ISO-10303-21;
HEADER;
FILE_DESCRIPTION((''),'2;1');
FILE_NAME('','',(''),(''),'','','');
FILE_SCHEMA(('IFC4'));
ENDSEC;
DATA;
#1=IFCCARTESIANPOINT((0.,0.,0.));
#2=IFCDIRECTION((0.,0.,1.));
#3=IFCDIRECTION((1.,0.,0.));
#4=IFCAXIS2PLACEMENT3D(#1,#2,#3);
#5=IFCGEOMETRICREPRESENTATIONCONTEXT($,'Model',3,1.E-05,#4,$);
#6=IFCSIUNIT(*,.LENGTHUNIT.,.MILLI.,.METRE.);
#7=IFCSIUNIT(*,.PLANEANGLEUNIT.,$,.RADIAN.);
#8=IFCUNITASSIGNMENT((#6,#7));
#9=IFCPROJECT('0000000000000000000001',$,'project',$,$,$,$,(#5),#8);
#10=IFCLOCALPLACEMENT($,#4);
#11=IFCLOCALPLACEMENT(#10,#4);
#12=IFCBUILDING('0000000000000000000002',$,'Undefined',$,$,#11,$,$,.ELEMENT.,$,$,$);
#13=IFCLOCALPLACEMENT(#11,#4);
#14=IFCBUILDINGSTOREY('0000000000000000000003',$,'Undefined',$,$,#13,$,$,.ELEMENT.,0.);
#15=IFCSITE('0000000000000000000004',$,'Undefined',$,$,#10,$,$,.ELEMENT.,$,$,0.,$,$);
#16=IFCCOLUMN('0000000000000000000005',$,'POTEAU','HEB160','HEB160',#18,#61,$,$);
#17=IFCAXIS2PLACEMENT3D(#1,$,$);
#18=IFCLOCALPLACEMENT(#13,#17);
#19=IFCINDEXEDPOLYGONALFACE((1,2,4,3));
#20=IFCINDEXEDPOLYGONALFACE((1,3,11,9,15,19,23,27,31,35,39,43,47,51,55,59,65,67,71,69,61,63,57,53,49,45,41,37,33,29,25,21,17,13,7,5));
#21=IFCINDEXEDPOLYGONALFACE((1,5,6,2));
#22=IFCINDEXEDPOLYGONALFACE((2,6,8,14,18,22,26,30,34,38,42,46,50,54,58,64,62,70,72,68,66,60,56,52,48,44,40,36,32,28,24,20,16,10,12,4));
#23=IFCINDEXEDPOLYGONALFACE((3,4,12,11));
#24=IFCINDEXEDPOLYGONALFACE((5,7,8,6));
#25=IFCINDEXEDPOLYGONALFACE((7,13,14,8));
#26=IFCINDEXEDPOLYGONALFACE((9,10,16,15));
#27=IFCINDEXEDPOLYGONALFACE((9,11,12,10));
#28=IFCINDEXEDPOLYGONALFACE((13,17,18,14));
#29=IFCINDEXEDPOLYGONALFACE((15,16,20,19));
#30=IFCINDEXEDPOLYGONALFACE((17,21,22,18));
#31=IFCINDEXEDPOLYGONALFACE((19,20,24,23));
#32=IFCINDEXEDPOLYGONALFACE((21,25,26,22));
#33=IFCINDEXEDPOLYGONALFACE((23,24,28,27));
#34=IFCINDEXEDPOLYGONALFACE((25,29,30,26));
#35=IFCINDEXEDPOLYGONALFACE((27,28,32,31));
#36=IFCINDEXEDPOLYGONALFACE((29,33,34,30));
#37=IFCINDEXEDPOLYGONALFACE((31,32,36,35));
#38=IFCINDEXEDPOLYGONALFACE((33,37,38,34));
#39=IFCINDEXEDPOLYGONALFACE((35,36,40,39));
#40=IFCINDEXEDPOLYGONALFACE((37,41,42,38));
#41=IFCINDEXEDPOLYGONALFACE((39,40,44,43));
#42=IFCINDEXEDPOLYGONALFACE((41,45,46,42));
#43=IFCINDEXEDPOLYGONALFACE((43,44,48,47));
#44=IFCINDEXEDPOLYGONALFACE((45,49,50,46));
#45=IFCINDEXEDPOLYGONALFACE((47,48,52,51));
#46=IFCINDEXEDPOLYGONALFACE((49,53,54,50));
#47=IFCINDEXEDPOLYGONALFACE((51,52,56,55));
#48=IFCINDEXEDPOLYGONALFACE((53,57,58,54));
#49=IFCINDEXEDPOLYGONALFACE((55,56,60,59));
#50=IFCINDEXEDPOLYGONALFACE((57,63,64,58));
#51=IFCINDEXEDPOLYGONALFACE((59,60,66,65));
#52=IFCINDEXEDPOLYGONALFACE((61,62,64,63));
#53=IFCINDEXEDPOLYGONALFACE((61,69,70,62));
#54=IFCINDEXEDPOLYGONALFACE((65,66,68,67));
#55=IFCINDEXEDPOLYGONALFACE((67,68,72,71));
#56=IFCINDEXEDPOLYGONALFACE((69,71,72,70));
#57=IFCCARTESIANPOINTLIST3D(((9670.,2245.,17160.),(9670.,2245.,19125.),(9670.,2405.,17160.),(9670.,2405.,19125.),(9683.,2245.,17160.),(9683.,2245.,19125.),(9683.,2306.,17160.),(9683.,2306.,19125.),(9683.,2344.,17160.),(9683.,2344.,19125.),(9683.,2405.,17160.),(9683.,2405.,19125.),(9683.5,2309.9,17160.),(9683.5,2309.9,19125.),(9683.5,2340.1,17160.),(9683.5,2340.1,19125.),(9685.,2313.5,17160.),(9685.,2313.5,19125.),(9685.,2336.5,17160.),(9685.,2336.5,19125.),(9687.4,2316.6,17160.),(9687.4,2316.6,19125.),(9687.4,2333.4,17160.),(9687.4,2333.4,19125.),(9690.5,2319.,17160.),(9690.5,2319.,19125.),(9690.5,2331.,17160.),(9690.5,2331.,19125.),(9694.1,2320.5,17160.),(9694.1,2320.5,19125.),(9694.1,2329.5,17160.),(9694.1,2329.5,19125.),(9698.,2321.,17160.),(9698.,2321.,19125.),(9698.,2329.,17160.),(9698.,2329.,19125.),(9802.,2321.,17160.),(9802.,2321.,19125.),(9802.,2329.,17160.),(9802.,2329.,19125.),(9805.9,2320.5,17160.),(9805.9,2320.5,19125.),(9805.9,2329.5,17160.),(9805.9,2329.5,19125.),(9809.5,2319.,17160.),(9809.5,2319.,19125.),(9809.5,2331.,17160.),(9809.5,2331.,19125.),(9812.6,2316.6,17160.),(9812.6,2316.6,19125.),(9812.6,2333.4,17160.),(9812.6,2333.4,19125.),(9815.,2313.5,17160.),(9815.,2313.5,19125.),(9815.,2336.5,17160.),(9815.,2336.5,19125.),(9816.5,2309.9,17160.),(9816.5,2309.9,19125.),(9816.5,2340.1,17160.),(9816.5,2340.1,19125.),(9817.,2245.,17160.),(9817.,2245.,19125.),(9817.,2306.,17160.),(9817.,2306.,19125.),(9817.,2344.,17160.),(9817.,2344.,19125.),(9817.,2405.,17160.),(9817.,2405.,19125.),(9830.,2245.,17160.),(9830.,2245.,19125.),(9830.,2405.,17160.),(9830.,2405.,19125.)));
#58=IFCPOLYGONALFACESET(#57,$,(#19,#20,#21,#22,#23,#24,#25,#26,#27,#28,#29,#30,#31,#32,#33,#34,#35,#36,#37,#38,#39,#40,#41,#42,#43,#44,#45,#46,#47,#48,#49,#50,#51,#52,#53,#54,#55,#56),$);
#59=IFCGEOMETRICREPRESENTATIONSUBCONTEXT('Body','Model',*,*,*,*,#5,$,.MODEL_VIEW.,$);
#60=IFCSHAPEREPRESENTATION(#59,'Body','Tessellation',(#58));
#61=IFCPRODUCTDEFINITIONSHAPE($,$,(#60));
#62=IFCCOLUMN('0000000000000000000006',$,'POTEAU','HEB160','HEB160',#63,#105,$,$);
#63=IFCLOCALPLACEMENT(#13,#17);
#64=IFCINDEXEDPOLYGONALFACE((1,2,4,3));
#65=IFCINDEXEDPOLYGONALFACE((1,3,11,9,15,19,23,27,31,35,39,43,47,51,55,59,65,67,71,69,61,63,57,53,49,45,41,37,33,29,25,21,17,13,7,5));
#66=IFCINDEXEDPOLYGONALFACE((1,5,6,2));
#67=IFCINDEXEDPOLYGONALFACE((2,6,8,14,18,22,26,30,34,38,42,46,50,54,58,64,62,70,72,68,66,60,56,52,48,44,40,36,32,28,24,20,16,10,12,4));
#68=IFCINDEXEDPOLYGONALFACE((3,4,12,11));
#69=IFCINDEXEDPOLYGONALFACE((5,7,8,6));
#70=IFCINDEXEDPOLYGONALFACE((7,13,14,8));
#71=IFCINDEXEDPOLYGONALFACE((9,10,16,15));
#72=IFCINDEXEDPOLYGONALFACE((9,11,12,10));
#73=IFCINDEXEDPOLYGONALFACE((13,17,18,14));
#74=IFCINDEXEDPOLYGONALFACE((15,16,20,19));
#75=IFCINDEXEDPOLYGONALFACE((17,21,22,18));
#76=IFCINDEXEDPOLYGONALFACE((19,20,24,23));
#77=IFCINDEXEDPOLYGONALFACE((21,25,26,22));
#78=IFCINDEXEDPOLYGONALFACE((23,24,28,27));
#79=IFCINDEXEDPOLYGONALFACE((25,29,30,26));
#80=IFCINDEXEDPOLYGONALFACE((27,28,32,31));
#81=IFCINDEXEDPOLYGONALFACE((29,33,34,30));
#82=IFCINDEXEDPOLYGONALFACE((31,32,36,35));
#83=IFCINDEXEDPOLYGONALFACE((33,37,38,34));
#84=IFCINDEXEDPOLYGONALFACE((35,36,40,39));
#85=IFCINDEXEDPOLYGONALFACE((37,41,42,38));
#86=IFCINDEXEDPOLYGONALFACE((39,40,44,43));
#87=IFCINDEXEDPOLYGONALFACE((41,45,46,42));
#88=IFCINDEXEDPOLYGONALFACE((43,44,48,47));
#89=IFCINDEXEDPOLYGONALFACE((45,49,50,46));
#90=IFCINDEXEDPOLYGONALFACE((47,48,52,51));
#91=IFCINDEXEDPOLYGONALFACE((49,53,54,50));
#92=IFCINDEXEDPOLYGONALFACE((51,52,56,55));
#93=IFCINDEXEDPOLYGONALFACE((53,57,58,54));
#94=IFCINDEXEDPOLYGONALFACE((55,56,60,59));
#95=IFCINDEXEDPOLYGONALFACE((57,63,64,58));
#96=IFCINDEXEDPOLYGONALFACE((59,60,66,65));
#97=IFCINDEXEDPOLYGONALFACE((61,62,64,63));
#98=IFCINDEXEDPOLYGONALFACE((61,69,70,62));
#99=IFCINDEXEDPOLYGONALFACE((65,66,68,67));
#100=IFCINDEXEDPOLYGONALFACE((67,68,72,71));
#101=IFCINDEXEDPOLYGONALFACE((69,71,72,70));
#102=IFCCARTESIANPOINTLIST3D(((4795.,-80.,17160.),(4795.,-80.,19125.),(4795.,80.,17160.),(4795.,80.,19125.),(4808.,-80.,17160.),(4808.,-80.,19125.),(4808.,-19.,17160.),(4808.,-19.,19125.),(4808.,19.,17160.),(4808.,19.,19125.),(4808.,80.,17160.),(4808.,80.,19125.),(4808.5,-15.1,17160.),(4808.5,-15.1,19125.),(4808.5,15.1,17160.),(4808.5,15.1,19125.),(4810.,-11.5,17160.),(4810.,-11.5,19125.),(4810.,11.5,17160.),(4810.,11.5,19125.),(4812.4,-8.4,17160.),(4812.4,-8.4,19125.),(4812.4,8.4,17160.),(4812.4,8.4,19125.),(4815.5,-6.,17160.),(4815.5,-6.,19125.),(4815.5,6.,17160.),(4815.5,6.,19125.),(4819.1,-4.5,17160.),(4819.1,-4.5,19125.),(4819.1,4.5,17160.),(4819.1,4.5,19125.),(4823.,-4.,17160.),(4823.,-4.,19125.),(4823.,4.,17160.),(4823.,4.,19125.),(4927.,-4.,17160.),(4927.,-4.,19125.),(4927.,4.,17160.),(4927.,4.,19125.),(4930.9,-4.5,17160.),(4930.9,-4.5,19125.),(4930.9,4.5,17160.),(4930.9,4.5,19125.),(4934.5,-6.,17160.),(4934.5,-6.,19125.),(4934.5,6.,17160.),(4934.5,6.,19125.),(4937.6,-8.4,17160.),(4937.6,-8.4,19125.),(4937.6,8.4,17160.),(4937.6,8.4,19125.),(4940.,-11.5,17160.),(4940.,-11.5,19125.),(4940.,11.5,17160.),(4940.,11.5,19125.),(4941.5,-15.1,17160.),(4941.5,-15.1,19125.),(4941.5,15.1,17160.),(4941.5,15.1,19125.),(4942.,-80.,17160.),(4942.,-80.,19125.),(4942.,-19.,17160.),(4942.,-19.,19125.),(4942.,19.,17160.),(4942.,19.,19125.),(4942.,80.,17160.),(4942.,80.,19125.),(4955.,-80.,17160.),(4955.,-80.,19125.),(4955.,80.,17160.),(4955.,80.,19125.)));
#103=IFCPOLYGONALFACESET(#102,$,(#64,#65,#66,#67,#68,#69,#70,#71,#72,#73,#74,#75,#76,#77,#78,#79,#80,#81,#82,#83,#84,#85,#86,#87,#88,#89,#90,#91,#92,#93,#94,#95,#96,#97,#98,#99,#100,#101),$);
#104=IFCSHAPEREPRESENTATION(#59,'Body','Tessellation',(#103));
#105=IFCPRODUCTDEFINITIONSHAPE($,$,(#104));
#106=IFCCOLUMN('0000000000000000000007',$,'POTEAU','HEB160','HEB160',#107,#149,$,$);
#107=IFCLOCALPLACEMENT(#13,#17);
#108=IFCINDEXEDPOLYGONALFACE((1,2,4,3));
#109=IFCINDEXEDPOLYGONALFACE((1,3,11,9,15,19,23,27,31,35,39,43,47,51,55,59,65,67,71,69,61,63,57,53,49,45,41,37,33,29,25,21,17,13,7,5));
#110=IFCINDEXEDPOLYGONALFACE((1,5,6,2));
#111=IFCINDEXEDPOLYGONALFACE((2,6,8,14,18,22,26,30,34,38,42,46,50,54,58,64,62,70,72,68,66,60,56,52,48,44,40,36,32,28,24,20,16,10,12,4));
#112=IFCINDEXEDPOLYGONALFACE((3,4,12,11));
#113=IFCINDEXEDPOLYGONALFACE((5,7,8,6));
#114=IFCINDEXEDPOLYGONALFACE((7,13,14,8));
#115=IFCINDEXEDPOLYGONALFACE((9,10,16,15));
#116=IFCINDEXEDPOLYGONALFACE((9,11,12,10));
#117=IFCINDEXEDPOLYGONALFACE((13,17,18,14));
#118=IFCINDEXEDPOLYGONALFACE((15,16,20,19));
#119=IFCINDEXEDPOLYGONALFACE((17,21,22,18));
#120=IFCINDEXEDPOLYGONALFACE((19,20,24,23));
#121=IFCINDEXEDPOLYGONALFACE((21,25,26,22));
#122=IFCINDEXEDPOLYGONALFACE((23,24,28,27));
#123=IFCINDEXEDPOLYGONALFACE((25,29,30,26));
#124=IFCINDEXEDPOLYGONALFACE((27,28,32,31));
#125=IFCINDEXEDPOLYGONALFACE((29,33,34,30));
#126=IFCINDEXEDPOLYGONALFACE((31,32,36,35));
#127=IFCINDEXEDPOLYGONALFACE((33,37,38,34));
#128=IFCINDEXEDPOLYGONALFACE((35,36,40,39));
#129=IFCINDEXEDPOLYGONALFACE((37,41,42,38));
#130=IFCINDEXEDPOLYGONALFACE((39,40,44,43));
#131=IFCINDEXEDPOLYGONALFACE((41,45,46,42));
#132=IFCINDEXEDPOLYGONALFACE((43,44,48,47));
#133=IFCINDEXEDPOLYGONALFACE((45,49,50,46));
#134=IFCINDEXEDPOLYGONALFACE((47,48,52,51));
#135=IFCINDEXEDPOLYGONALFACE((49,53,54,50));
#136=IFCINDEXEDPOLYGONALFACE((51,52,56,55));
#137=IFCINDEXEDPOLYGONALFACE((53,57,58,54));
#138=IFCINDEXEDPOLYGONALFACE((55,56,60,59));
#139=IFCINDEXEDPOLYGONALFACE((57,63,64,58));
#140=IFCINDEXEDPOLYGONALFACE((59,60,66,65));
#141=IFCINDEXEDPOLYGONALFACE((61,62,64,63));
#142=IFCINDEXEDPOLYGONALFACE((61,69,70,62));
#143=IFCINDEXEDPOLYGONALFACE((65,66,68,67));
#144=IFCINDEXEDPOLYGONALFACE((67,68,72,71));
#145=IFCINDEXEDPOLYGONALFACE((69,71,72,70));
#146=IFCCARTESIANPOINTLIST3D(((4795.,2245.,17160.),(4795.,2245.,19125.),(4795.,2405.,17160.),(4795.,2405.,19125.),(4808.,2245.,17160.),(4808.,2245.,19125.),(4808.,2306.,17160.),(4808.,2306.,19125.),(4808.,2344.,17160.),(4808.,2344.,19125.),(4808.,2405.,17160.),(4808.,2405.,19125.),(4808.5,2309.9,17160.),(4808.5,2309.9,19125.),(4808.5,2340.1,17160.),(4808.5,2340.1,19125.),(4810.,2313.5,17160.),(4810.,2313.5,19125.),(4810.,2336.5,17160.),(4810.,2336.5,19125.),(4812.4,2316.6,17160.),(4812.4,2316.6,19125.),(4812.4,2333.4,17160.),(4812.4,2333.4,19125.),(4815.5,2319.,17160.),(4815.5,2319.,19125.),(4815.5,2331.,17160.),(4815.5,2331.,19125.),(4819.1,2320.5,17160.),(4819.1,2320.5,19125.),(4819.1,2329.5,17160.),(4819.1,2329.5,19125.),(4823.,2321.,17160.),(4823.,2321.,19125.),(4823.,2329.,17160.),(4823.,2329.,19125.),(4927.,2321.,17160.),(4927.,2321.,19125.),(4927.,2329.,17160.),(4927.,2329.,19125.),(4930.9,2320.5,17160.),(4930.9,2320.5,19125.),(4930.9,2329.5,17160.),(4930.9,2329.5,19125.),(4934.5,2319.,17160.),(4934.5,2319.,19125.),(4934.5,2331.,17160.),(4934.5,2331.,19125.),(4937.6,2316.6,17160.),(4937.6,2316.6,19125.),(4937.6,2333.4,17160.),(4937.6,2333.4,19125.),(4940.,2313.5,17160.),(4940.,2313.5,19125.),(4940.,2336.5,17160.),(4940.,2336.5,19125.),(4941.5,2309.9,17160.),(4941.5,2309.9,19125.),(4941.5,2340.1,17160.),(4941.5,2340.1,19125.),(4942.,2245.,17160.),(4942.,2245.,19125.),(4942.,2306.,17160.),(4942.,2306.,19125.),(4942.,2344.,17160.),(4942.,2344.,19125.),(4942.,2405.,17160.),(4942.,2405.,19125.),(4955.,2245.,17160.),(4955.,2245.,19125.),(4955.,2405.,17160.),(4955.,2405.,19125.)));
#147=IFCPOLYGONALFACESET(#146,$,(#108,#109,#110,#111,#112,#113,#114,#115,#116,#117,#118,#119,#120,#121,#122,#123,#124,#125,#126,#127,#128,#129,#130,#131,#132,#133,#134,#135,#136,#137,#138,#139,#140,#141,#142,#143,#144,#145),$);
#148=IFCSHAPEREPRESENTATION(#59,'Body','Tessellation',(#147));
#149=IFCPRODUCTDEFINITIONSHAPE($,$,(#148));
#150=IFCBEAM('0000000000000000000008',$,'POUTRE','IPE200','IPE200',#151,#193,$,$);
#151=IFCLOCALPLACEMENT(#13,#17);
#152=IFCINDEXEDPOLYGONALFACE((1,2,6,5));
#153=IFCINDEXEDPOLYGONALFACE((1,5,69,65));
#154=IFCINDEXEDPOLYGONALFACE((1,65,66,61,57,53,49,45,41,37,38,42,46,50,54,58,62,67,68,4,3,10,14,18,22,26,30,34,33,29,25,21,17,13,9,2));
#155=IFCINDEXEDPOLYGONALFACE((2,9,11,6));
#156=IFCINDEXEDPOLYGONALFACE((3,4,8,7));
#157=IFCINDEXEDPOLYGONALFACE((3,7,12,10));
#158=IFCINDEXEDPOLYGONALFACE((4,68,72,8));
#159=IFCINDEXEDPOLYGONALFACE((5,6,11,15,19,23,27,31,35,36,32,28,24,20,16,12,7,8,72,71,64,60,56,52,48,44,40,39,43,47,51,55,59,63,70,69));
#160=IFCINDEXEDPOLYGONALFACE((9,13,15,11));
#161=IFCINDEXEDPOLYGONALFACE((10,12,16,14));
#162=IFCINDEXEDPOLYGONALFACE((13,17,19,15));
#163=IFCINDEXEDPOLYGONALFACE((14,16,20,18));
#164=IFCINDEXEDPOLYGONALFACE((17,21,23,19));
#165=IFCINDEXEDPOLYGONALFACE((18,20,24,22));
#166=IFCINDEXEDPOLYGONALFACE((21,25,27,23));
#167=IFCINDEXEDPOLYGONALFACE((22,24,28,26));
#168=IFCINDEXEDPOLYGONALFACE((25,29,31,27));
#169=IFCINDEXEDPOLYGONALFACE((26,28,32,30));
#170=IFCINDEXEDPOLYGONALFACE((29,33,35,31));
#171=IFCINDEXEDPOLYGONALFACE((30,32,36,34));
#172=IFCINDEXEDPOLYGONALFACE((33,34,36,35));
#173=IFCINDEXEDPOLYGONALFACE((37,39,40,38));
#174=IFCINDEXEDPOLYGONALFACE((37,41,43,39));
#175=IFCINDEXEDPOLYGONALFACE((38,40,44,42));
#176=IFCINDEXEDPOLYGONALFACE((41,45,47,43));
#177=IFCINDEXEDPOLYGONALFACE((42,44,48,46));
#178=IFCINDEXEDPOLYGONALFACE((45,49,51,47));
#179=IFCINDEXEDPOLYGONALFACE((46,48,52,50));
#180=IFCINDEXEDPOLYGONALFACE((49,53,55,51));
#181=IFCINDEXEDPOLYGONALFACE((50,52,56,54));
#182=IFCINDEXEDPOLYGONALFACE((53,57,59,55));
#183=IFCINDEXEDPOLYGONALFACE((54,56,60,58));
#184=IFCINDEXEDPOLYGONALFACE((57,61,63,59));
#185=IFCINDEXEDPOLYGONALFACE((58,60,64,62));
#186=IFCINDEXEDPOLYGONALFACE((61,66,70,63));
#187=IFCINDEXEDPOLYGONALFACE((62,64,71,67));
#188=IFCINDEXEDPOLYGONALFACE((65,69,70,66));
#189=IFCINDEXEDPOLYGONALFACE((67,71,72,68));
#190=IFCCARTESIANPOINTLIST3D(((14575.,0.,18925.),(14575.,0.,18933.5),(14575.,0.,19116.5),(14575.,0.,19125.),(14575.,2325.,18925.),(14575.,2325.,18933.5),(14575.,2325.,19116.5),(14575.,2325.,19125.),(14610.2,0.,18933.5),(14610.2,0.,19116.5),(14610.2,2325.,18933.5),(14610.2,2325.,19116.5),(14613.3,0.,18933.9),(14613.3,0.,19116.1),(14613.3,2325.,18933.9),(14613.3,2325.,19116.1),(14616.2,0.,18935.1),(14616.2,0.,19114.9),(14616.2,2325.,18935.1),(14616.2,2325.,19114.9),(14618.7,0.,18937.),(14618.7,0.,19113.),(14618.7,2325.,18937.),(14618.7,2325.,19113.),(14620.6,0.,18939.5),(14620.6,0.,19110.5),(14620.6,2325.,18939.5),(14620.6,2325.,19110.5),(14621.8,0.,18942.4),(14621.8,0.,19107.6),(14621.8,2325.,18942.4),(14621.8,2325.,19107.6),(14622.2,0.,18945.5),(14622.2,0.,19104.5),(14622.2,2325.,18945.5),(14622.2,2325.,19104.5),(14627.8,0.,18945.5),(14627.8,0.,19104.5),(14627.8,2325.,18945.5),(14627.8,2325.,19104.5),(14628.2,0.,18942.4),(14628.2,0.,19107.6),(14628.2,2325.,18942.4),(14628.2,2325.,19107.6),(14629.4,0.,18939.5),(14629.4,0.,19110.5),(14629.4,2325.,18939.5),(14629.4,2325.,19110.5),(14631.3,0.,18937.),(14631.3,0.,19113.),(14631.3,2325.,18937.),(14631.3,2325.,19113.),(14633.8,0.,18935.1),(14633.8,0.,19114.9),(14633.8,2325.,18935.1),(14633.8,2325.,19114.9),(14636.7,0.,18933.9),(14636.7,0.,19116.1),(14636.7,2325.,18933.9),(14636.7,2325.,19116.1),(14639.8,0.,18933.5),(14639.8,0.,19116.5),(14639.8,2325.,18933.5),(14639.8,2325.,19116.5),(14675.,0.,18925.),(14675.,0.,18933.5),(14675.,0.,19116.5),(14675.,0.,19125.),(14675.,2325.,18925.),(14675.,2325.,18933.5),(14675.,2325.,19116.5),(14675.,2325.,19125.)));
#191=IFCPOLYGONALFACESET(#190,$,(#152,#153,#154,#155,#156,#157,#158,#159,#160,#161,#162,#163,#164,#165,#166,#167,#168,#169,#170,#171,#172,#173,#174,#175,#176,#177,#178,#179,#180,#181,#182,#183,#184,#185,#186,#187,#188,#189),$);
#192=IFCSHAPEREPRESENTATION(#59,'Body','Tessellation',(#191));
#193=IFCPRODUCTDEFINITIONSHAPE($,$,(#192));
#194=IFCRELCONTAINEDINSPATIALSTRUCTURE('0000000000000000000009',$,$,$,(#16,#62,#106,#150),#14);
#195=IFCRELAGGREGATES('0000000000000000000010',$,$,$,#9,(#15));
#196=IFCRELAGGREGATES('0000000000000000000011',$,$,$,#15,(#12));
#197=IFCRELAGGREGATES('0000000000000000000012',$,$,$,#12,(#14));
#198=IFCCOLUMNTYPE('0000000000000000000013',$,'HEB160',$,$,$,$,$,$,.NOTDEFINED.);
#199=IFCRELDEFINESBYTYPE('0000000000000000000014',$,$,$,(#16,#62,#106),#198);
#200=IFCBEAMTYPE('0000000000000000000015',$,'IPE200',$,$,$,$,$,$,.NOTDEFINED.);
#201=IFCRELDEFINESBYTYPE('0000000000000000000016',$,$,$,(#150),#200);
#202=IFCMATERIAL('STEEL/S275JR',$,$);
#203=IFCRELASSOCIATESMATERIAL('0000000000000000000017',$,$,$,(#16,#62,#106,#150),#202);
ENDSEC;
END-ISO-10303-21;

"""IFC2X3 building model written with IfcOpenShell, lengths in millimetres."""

from ifc_helpers import new_model, si_unit, frame, origin_with_axes, origin_2d_with_axis, place, context, subcontext, project, spatial, i_section, extrude, material, type_object, element, save


model = new_model("IFC2X3")

# Units and contexts
model_context = context("Model", 3, precision=1e-05, world=origin_with_axes())
body_context = subcontext(model_context, "Body", "Model", "MODEL_VIEW")
ifc_project = project(units=[si_unit("LENGTHUNIT", "METRE", prefix="MILLI"), si_unit("PLANEANGLEUNIT", "RADIAN")], contexts=[model_context])

# Site, building, storey
site_placement = place(None, origin_with_axes())
site = spatial("IfcSite", under=ifc_project, at=site_placement, Name="Undefined", CompositionType="ELEMENT", RefElevation=0.0)
building_placement = place(site_placement, origin_with_axes())
building = spatial("IfcBuilding", under=site, at=building_placement, Name="Undefined", CompositionType="ELEMENT")
storey_placement = place(building_placement, origin_with_axes())
storey = spatial("IfcBuildingStorey", under=building, at=storey_placement, Name="Undefined", CompositionType="ELEMENT", Elevation=0.0)

# Columns
ifc_material_1 = material(Name="STEEL/S275JR")
column_type_1 = type_object("IfcColumnType", Name="HEB160", PredefinedType="NOTDEFINED")
for number, where, z_axis, x_axis, name in (
    (1, (9750.0, 2325.0, 17160.0), (0.0, 0.0, 1.0), (1.0, 0.0, 0.0), "POTEAU"),
    (2, (4875.0, 0.0, 17160.0), (0.0, 0.0, 1.0), (1.0, 0.0, 0.0), "POTEAU"),
    (3, (4875.0, 2325.0, 17160.0), (0.0, 0.0, 1.0), (1.0, 0.0, 0.0), "POTEAU"),
):
    element("IfcColumn", number, at=place(storey_placement, frame(where, z_axis=z_axis, x_axis=x_axis)), inside=storey, type_object=column_type_1, material=ifc_material_1, Name=name, Description="HEB160", ObjectType="HEB160", context=body_context, shape_type="SweptSolid", body=[
        extrude(i_section(OverallWidth=160.0, OverallDepth=160.0, WebThickness=8.0, FlangeThickness=13.0, FilletRadius=15.0, at=origin_2d_with_axis()), frame((0.0, 0.0, 1965.0), z_axis=(0.0, 0.0, -1.0), x_axis=(0.0, -1.0, 0.0)), (0.0, 0.0, 1.0), 1965.0),
    ])

# Beam
beam_type_1 = type_object("IfcBeamType", Name="IPE200", PredefinedType="NOTDEFINED")
for number, where, z_axis, x_axis, name in (
    (4, (14625.0, 0.0, 19025.0), (0.0, 0.000013, 1.0), (0.0, 1.0, -0.000013), "POUTRE"),
):
    element("IfcBeam", number, at=place(storey_placement, frame(where, z_axis=z_axis, x_axis=x_axis)), inside=storey, type_object=beam_type_1, material=ifc_material_1, Name=name, Description="IPE200", ObjectType="IPE200", context=body_context, shape_type="SweptSolid", body=[
        extrude(i_section(OverallWidth=100.0, OverallDepth=200.0, WebThickness=5.6, FlangeThickness=8.5, FilletRadius=12.0, at=origin_2d_with_axis()), frame((2325.0, 0.0, 0.0), z_axis=(-1.0, 0.0, 0.0), x_axis=(0.0, -1.0, 0.0)), (0.0, 0.0, 1.0), 2325.0),
    ])

save(model, "model.ifc")
